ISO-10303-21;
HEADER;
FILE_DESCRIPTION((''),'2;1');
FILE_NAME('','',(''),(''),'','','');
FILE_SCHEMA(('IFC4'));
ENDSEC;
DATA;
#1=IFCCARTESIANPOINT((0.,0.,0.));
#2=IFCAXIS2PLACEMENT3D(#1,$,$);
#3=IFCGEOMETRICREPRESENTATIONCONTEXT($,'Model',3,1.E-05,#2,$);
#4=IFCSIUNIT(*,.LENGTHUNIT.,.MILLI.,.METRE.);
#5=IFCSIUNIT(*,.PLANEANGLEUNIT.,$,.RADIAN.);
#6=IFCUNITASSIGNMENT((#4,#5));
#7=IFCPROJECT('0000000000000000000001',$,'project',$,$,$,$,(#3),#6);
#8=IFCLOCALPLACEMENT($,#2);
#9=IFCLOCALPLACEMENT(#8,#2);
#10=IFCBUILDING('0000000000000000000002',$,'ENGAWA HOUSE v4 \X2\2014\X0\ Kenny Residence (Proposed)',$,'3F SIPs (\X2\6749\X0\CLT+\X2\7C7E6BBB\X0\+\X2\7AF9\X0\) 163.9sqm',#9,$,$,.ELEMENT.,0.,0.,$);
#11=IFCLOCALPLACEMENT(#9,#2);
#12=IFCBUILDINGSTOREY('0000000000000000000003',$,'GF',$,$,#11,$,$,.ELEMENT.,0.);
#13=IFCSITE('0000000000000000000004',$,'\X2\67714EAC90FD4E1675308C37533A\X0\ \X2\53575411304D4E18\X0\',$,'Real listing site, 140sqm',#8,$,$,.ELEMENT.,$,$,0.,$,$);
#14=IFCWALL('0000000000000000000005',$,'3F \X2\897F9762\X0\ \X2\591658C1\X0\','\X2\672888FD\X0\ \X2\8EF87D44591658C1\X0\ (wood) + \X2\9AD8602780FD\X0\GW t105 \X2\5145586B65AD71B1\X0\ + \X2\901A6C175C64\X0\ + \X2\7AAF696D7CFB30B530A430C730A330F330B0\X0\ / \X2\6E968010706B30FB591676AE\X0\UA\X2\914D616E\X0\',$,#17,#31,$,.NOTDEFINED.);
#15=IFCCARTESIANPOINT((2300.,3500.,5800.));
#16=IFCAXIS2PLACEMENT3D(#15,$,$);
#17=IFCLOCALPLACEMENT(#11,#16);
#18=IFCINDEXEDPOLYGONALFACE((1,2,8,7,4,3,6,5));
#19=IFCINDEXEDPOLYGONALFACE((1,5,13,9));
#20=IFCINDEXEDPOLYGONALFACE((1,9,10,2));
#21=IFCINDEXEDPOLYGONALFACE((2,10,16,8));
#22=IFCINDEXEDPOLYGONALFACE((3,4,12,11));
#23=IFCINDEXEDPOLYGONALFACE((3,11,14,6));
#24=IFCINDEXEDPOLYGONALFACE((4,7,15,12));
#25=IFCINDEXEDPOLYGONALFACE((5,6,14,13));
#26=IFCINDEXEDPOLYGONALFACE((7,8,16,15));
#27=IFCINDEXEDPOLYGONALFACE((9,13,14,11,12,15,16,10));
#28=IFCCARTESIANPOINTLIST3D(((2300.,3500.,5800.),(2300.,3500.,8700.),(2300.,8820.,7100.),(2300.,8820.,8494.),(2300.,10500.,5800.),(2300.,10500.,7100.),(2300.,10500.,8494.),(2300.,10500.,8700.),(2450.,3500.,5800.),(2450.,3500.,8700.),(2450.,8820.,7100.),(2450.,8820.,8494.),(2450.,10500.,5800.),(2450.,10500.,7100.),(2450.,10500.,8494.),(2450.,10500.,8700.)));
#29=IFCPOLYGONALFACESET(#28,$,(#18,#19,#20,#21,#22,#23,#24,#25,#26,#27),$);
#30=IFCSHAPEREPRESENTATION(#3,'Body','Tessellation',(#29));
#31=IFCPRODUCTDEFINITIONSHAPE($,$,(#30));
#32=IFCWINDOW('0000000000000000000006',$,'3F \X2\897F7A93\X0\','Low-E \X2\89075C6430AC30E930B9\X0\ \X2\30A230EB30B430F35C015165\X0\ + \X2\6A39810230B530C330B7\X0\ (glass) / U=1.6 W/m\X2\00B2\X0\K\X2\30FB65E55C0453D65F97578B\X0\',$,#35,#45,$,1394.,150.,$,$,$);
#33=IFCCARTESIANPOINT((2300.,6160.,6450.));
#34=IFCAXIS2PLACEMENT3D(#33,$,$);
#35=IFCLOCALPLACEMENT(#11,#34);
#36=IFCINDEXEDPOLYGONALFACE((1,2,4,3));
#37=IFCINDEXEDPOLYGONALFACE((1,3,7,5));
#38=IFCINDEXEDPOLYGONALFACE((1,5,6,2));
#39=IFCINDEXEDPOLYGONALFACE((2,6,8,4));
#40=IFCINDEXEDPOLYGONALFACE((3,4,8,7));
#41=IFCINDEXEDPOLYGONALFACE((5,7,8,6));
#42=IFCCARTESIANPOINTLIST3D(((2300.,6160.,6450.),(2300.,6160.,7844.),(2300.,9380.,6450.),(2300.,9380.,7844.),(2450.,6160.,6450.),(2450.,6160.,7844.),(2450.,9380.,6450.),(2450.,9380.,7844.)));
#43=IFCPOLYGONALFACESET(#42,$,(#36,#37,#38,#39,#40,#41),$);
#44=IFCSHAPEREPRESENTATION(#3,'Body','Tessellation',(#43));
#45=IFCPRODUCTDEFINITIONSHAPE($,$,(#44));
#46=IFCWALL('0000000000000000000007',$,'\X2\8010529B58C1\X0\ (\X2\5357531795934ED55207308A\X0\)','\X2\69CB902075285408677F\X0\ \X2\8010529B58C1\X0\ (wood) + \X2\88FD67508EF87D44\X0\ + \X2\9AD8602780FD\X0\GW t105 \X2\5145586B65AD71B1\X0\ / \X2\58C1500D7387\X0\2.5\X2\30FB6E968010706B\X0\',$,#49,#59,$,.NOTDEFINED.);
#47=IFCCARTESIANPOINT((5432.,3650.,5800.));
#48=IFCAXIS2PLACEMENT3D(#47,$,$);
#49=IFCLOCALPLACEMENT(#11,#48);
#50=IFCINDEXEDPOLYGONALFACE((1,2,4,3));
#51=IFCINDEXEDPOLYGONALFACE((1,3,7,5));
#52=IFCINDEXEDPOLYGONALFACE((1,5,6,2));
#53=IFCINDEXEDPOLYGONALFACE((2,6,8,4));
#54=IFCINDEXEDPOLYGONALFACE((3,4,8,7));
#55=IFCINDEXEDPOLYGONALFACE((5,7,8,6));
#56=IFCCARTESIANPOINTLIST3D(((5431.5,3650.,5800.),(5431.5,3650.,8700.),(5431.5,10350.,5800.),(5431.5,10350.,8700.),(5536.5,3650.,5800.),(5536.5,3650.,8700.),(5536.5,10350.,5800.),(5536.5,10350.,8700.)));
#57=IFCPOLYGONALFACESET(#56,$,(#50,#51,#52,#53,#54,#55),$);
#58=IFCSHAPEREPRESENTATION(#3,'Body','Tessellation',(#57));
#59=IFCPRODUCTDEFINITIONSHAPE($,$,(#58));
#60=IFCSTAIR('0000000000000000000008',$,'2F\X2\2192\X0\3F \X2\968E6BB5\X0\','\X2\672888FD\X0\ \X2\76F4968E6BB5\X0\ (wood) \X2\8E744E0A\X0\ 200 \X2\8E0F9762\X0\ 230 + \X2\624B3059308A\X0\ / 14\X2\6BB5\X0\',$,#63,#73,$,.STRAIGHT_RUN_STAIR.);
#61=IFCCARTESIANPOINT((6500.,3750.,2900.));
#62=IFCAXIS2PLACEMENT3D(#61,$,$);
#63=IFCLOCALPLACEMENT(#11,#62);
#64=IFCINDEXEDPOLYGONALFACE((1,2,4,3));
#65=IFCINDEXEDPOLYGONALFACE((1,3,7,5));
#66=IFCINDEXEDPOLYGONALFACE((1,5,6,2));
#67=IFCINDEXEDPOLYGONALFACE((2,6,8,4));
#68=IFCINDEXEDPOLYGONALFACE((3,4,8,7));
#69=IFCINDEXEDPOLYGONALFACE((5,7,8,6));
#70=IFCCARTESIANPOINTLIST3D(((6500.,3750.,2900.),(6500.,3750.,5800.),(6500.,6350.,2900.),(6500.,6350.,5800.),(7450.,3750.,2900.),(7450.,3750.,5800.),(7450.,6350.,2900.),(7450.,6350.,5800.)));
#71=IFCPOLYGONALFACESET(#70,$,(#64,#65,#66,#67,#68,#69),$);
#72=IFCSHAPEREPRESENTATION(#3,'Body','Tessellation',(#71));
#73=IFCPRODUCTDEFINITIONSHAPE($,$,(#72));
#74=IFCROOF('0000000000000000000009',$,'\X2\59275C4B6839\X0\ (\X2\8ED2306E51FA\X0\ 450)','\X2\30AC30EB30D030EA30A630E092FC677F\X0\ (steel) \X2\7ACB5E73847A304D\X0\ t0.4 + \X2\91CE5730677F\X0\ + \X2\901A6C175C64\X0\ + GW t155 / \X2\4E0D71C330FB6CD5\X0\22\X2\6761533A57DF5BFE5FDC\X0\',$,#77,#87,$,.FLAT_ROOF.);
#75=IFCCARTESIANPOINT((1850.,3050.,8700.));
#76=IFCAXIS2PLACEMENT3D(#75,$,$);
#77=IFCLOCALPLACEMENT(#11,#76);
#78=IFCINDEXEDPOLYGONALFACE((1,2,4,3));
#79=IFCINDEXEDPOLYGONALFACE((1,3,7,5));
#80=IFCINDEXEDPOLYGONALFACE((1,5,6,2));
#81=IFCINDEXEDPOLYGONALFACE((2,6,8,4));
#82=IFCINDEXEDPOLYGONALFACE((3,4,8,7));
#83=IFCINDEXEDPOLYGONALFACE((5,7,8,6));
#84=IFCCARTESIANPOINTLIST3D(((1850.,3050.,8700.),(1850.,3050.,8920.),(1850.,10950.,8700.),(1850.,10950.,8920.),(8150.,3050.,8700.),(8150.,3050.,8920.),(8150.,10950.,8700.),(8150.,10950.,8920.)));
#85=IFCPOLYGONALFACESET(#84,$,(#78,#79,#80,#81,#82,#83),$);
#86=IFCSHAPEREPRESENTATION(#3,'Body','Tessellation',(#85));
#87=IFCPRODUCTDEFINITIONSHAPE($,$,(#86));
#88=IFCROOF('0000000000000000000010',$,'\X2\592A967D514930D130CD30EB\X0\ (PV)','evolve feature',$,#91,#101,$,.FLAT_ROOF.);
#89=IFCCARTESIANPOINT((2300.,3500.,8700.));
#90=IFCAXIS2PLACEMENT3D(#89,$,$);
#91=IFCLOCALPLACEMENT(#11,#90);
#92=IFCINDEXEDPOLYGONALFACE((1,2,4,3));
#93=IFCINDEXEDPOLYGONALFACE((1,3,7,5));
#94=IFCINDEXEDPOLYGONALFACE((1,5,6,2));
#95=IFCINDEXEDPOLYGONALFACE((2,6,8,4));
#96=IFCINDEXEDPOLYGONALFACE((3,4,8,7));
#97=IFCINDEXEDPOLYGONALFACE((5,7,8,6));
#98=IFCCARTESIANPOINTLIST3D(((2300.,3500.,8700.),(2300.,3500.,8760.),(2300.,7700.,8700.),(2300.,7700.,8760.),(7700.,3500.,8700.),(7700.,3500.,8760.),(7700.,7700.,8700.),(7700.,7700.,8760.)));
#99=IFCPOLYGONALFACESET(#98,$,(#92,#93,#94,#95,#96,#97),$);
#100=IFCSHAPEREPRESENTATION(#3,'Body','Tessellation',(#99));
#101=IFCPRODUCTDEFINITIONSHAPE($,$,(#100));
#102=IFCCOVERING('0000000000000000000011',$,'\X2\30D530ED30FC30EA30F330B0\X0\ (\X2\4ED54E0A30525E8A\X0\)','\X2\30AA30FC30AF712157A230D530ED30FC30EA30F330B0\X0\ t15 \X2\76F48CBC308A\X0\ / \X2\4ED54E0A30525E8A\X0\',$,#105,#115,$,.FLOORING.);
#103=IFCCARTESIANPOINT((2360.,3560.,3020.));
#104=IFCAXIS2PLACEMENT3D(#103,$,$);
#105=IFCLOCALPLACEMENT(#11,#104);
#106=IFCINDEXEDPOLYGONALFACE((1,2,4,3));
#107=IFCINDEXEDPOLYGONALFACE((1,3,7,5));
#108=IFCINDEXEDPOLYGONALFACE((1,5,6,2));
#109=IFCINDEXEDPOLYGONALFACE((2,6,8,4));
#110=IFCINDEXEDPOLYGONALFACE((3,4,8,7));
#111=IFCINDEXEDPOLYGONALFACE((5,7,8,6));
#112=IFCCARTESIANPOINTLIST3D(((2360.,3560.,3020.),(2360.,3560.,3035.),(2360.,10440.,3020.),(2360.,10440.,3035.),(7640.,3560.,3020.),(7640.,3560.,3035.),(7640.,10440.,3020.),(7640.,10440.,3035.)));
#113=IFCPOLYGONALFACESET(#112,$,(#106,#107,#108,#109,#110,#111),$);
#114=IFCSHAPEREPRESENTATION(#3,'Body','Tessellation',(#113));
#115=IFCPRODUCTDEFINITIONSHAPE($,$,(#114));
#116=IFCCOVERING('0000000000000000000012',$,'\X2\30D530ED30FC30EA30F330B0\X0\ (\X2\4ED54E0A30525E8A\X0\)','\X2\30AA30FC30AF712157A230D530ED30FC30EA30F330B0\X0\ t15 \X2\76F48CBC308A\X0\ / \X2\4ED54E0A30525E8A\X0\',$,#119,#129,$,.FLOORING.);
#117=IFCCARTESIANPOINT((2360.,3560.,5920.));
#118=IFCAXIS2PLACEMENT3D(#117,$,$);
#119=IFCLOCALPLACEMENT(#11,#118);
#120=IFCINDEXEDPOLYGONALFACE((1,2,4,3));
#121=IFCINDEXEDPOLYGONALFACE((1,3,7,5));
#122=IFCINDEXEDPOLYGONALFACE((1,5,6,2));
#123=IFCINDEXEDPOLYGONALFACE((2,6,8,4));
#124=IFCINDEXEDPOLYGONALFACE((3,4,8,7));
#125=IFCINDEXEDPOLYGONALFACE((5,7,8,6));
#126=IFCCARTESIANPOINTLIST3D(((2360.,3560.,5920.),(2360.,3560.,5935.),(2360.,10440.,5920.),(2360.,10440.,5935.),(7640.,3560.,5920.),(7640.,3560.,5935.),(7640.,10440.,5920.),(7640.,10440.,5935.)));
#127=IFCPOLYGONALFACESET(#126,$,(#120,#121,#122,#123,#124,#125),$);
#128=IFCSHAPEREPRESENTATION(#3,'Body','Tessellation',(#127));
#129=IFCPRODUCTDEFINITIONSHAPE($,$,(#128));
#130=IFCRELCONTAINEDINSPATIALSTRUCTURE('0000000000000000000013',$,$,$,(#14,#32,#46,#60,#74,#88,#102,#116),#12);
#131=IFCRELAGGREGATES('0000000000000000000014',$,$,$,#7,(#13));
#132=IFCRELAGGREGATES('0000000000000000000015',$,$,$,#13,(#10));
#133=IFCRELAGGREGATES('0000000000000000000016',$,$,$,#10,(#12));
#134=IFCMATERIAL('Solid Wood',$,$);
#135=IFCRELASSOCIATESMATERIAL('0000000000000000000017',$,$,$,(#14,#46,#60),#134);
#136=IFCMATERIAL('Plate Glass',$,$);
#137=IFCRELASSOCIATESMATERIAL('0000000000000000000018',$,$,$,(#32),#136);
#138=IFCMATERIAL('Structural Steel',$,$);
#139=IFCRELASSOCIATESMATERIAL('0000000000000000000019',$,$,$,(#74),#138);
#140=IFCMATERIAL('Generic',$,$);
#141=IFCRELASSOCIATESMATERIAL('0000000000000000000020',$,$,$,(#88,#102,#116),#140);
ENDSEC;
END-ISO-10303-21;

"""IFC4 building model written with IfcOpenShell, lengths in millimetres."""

from ifc_helpers import new_model, si_unit, frame, frame_2d, origin, place, context, project, spatial, rectangle, extrude, material, element, fill, save


model = new_model("IFC4")

# Units and contexts
model_context = context("Model", 3, precision=1e-05, world=origin())
ifc_project = project(units=[si_unit("LENGTHUNIT", "METRE", prefix="MILLI"), si_unit("PLANEANGLEUNIT", "RADIAN")], contexts=[model_context])

# Site, building, storey
site_placement = place(None, origin())
site = spatial("IfcSite", under=ifc_project, at=site_placement, Name="東京都世田谷区 南向き丘", ObjectType="Real listing site, 140sqm", CompositionType="ELEMENT", RefElevation=0.0)
building_placement = place(site_placement, origin())
building = spatial("IfcBuilding", under=site, at=building_placement, Name="ENGAWA HOUSE v4 — Kenny Residence (Proposed)", ObjectType="3F SIPs (杉CLT+籾殻+竹) 163.9sqm", CompositionType="ELEMENT", ElevationOfRefHeight=0.0, ElevationOfTerrain=0.0)
storey_placement = place(building_placement, origin())
storey = spatial("IfcBuildingStorey", under=building, at=storey_placement, Name="GF", CompositionType="ELEMENT", Elevation=0.0)

# Shared definitions
ifc_material_1 = material(Name="Solid Wood")

# Shared definitions
ifc_material_2 = material(Name="Plate Glass")

# Shared definitions
ifc_material_3 = material(Name="Generic")

# Wall, opening, window
wall_1_placement = place(storey_placement, frame((2300.0, 3500.0, 5800.0)))
wall_1 = element("IfcWall", 1, at=wall_1_placement, inside=storey, material=ifc_material_1, Name="3F 西面 外壁", Description="木製 軸組外壁 (wood) + 高性能GW t105 充填断熱 + 通気層 + 窯業系サイディング / 準耐火・外皮UA配慮", PredefinedType="NOTDEFINED", context=model_context, shape_type="SweptSolid", body=[
    extrude(rectangle(XDim=150.0, YDim=7000.0, at=frame_2d((75.0, 3500.0))), frame((2300.0, 3500.0, 5800.0)), (0.0, 0.0, 1.0), 2900.0),
])
opening_1_placement = place(storey_placement, frame((2300.0, 6160.0, 6450.0)))
opening_1 = element("IfcOpeningElement", 2, at=opening_1_placement, cuts=wall_1, PredefinedType="NOTDEFINED", context=model_context, shape_type="SweptSolid", body=[
    extrude(rectangle(XDim=150.0, YDim=3220.0, at=frame_2d((75.0, 1610.0))), frame((2300.0, 6160.0, 6450.0)), (0.0, 0.0, 1.0), 1394.0),
])
window_1_placement = place(storey_placement, frame((2300.0, 6160.0, 6450.0)))
window_1 = element("IfcWindow", 3, at=window_1_placement, inside=storey, material=ifc_material_2, Name="3F 西窓", Description="Low-E 複層ガラス アルゴン封入 + 樹脂サッシ (glass) / U=1.6 W/m²K・日射取得型", OverallHeight=1394.0, OverallWidth=150.0, context=model_context, shape_type="SweptSolid", body=[
    extrude(rectangle(XDim=150.0, YDim=3220.0, at=frame_2d((75.0, 1610.0))), frame((2300.0, 6160.0, 6450.0)), (0.0, 0.0, 1.0), 1394.0),
])
fill(opening_1, window_1)

# Wall
wall_2_placement = place(storey_placement, frame((5432.0, 3650.0, 5800.0)))
element("IfcWall", 4, at=wall_2_placement, inside=storey, material=ifc_material_1, Name="耐力壁 (南北間仕切り)", Description="構造用合板 耐力壁 (wood) + 製材軸組 + 高性能GW t105 充填断熱 / 壁倍率2.5・準耐火", PredefinedType="NOTDEFINED", context=model_context, shape_type="SweptSolid", body=[
    extrude(rectangle(XDim=105.0, YDim=6700.0, at=frame_2d((52.0, 3350.0))), frame((5432.0, 3650.0, 5800.0)), (0.0, 0.0, 1.0), 2900.0),
])

# Stair
stair_placement = place(storey_placement, frame((6500.0, 3750.0, 2900.0)))
element("IfcStair", 5, at=stair_placement, inside=storey, material=ifc_material_1, Name="2F→3F 階段", Description="木製 直階段 (wood) 蹴上 200 踏面 230 + 手すり / 14段", PredefinedType="STRAIGHT_RUN_STAIR", context=model_context, shape_type="SweptSolid", body=[
    extrude(rectangle(XDim=950.0, YDim=2600.0, at=frame_2d((475.0, 1300.0))), frame((6500.0, 3750.0, 2900.0)), (0.0, 0.0, 1.0), 2900.0),
])

# Roofs
ifc_material_4 = material(Name="Structural Steel")
roof_1_placement = place(storey_placement, frame((1850.0, 3050.0, 8700.0)))
element("IfcRoof", 6, at=roof_1_placement, inside=storey, material=ifc_material_4, Name="大屋根 (軒の出 450)", Description="ガルバリウム鋼板 (steel) 立平葺き t0.4 + 野地板 + 通気層 + GW t155 / 不燃・法22条区域対応", PredefinedType="FLAT_ROOF", context=model_context, shape_type="SweptSolid", body=[
    extrude(rectangle(XDim=6300.0, YDim=7900.0, at=frame_2d((3150.0, 3950.0))), frame((1850.0, 3050.0, 8700.0)), (0.0, 0.0, 1.0), 220.0),
])
roof_2_placement = place(storey_placement, frame((2300.0, 3500.0, 8700.0)))
element("IfcRoof", 7, at=roof_2_placement, inside=storey, material=ifc_material_3, Name="太陽光パネル (PV)", Description="evolve feature", PredefinedType="FLAT_ROOF", context=model_context, shape_type="SweptSolid", body=[
    extrude(rectangle(XDim=5400.0, YDim=4200.0, at=frame_2d((2700.0, 2100.0))), frame((2300.0, 3500.0, 8700.0)), (0.0, 0.0, 1.0), 60.0),
])

# Coverings
covering_1_placement = place(storey_placement, frame((2360.0, 3560.0, 3020.0)))
element("IfcCovering", 8, at=covering_1_placement, inside=storey, material=ifc_material_3, Name="フローリング (仕上げ床)", Description="オーク無垢フローリング t15 直貼り / 仕上げ床", PredefinedType="FLOORING", context=model_context, shape_type="SweptSolid", body=[
    extrude(rectangle(XDim=5280.0, YDim=6880.0, at=frame_2d((2640.0, 3440.0))), frame((2360.0, 3560.0, 3020.0)), (0.0, 0.0, 1.0), 15.0),
])
covering_2_placement = place(storey_placement, frame((2360.0, 3560.0, 5920.0)))
element("IfcCovering", 9, at=covering_2_placement, inside=storey, material=ifc_material_3, Name="フローリング (仕上げ床)", Description="オーク無垢フローリング t15 直貼り / 仕上げ床", PredefinedType="FLOORING", context=model_context, shape_type="SweptSolid", body=[
    extrude(rectangle(XDim=5280.0, YDim=6880.0, at=frame_2d((2640.0, 3440.0))), frame((2360.0, 3560.0, 5920.0)), (0.0, 0.0, 1.0), 15.0),
])

save(model, "model.ifc")
